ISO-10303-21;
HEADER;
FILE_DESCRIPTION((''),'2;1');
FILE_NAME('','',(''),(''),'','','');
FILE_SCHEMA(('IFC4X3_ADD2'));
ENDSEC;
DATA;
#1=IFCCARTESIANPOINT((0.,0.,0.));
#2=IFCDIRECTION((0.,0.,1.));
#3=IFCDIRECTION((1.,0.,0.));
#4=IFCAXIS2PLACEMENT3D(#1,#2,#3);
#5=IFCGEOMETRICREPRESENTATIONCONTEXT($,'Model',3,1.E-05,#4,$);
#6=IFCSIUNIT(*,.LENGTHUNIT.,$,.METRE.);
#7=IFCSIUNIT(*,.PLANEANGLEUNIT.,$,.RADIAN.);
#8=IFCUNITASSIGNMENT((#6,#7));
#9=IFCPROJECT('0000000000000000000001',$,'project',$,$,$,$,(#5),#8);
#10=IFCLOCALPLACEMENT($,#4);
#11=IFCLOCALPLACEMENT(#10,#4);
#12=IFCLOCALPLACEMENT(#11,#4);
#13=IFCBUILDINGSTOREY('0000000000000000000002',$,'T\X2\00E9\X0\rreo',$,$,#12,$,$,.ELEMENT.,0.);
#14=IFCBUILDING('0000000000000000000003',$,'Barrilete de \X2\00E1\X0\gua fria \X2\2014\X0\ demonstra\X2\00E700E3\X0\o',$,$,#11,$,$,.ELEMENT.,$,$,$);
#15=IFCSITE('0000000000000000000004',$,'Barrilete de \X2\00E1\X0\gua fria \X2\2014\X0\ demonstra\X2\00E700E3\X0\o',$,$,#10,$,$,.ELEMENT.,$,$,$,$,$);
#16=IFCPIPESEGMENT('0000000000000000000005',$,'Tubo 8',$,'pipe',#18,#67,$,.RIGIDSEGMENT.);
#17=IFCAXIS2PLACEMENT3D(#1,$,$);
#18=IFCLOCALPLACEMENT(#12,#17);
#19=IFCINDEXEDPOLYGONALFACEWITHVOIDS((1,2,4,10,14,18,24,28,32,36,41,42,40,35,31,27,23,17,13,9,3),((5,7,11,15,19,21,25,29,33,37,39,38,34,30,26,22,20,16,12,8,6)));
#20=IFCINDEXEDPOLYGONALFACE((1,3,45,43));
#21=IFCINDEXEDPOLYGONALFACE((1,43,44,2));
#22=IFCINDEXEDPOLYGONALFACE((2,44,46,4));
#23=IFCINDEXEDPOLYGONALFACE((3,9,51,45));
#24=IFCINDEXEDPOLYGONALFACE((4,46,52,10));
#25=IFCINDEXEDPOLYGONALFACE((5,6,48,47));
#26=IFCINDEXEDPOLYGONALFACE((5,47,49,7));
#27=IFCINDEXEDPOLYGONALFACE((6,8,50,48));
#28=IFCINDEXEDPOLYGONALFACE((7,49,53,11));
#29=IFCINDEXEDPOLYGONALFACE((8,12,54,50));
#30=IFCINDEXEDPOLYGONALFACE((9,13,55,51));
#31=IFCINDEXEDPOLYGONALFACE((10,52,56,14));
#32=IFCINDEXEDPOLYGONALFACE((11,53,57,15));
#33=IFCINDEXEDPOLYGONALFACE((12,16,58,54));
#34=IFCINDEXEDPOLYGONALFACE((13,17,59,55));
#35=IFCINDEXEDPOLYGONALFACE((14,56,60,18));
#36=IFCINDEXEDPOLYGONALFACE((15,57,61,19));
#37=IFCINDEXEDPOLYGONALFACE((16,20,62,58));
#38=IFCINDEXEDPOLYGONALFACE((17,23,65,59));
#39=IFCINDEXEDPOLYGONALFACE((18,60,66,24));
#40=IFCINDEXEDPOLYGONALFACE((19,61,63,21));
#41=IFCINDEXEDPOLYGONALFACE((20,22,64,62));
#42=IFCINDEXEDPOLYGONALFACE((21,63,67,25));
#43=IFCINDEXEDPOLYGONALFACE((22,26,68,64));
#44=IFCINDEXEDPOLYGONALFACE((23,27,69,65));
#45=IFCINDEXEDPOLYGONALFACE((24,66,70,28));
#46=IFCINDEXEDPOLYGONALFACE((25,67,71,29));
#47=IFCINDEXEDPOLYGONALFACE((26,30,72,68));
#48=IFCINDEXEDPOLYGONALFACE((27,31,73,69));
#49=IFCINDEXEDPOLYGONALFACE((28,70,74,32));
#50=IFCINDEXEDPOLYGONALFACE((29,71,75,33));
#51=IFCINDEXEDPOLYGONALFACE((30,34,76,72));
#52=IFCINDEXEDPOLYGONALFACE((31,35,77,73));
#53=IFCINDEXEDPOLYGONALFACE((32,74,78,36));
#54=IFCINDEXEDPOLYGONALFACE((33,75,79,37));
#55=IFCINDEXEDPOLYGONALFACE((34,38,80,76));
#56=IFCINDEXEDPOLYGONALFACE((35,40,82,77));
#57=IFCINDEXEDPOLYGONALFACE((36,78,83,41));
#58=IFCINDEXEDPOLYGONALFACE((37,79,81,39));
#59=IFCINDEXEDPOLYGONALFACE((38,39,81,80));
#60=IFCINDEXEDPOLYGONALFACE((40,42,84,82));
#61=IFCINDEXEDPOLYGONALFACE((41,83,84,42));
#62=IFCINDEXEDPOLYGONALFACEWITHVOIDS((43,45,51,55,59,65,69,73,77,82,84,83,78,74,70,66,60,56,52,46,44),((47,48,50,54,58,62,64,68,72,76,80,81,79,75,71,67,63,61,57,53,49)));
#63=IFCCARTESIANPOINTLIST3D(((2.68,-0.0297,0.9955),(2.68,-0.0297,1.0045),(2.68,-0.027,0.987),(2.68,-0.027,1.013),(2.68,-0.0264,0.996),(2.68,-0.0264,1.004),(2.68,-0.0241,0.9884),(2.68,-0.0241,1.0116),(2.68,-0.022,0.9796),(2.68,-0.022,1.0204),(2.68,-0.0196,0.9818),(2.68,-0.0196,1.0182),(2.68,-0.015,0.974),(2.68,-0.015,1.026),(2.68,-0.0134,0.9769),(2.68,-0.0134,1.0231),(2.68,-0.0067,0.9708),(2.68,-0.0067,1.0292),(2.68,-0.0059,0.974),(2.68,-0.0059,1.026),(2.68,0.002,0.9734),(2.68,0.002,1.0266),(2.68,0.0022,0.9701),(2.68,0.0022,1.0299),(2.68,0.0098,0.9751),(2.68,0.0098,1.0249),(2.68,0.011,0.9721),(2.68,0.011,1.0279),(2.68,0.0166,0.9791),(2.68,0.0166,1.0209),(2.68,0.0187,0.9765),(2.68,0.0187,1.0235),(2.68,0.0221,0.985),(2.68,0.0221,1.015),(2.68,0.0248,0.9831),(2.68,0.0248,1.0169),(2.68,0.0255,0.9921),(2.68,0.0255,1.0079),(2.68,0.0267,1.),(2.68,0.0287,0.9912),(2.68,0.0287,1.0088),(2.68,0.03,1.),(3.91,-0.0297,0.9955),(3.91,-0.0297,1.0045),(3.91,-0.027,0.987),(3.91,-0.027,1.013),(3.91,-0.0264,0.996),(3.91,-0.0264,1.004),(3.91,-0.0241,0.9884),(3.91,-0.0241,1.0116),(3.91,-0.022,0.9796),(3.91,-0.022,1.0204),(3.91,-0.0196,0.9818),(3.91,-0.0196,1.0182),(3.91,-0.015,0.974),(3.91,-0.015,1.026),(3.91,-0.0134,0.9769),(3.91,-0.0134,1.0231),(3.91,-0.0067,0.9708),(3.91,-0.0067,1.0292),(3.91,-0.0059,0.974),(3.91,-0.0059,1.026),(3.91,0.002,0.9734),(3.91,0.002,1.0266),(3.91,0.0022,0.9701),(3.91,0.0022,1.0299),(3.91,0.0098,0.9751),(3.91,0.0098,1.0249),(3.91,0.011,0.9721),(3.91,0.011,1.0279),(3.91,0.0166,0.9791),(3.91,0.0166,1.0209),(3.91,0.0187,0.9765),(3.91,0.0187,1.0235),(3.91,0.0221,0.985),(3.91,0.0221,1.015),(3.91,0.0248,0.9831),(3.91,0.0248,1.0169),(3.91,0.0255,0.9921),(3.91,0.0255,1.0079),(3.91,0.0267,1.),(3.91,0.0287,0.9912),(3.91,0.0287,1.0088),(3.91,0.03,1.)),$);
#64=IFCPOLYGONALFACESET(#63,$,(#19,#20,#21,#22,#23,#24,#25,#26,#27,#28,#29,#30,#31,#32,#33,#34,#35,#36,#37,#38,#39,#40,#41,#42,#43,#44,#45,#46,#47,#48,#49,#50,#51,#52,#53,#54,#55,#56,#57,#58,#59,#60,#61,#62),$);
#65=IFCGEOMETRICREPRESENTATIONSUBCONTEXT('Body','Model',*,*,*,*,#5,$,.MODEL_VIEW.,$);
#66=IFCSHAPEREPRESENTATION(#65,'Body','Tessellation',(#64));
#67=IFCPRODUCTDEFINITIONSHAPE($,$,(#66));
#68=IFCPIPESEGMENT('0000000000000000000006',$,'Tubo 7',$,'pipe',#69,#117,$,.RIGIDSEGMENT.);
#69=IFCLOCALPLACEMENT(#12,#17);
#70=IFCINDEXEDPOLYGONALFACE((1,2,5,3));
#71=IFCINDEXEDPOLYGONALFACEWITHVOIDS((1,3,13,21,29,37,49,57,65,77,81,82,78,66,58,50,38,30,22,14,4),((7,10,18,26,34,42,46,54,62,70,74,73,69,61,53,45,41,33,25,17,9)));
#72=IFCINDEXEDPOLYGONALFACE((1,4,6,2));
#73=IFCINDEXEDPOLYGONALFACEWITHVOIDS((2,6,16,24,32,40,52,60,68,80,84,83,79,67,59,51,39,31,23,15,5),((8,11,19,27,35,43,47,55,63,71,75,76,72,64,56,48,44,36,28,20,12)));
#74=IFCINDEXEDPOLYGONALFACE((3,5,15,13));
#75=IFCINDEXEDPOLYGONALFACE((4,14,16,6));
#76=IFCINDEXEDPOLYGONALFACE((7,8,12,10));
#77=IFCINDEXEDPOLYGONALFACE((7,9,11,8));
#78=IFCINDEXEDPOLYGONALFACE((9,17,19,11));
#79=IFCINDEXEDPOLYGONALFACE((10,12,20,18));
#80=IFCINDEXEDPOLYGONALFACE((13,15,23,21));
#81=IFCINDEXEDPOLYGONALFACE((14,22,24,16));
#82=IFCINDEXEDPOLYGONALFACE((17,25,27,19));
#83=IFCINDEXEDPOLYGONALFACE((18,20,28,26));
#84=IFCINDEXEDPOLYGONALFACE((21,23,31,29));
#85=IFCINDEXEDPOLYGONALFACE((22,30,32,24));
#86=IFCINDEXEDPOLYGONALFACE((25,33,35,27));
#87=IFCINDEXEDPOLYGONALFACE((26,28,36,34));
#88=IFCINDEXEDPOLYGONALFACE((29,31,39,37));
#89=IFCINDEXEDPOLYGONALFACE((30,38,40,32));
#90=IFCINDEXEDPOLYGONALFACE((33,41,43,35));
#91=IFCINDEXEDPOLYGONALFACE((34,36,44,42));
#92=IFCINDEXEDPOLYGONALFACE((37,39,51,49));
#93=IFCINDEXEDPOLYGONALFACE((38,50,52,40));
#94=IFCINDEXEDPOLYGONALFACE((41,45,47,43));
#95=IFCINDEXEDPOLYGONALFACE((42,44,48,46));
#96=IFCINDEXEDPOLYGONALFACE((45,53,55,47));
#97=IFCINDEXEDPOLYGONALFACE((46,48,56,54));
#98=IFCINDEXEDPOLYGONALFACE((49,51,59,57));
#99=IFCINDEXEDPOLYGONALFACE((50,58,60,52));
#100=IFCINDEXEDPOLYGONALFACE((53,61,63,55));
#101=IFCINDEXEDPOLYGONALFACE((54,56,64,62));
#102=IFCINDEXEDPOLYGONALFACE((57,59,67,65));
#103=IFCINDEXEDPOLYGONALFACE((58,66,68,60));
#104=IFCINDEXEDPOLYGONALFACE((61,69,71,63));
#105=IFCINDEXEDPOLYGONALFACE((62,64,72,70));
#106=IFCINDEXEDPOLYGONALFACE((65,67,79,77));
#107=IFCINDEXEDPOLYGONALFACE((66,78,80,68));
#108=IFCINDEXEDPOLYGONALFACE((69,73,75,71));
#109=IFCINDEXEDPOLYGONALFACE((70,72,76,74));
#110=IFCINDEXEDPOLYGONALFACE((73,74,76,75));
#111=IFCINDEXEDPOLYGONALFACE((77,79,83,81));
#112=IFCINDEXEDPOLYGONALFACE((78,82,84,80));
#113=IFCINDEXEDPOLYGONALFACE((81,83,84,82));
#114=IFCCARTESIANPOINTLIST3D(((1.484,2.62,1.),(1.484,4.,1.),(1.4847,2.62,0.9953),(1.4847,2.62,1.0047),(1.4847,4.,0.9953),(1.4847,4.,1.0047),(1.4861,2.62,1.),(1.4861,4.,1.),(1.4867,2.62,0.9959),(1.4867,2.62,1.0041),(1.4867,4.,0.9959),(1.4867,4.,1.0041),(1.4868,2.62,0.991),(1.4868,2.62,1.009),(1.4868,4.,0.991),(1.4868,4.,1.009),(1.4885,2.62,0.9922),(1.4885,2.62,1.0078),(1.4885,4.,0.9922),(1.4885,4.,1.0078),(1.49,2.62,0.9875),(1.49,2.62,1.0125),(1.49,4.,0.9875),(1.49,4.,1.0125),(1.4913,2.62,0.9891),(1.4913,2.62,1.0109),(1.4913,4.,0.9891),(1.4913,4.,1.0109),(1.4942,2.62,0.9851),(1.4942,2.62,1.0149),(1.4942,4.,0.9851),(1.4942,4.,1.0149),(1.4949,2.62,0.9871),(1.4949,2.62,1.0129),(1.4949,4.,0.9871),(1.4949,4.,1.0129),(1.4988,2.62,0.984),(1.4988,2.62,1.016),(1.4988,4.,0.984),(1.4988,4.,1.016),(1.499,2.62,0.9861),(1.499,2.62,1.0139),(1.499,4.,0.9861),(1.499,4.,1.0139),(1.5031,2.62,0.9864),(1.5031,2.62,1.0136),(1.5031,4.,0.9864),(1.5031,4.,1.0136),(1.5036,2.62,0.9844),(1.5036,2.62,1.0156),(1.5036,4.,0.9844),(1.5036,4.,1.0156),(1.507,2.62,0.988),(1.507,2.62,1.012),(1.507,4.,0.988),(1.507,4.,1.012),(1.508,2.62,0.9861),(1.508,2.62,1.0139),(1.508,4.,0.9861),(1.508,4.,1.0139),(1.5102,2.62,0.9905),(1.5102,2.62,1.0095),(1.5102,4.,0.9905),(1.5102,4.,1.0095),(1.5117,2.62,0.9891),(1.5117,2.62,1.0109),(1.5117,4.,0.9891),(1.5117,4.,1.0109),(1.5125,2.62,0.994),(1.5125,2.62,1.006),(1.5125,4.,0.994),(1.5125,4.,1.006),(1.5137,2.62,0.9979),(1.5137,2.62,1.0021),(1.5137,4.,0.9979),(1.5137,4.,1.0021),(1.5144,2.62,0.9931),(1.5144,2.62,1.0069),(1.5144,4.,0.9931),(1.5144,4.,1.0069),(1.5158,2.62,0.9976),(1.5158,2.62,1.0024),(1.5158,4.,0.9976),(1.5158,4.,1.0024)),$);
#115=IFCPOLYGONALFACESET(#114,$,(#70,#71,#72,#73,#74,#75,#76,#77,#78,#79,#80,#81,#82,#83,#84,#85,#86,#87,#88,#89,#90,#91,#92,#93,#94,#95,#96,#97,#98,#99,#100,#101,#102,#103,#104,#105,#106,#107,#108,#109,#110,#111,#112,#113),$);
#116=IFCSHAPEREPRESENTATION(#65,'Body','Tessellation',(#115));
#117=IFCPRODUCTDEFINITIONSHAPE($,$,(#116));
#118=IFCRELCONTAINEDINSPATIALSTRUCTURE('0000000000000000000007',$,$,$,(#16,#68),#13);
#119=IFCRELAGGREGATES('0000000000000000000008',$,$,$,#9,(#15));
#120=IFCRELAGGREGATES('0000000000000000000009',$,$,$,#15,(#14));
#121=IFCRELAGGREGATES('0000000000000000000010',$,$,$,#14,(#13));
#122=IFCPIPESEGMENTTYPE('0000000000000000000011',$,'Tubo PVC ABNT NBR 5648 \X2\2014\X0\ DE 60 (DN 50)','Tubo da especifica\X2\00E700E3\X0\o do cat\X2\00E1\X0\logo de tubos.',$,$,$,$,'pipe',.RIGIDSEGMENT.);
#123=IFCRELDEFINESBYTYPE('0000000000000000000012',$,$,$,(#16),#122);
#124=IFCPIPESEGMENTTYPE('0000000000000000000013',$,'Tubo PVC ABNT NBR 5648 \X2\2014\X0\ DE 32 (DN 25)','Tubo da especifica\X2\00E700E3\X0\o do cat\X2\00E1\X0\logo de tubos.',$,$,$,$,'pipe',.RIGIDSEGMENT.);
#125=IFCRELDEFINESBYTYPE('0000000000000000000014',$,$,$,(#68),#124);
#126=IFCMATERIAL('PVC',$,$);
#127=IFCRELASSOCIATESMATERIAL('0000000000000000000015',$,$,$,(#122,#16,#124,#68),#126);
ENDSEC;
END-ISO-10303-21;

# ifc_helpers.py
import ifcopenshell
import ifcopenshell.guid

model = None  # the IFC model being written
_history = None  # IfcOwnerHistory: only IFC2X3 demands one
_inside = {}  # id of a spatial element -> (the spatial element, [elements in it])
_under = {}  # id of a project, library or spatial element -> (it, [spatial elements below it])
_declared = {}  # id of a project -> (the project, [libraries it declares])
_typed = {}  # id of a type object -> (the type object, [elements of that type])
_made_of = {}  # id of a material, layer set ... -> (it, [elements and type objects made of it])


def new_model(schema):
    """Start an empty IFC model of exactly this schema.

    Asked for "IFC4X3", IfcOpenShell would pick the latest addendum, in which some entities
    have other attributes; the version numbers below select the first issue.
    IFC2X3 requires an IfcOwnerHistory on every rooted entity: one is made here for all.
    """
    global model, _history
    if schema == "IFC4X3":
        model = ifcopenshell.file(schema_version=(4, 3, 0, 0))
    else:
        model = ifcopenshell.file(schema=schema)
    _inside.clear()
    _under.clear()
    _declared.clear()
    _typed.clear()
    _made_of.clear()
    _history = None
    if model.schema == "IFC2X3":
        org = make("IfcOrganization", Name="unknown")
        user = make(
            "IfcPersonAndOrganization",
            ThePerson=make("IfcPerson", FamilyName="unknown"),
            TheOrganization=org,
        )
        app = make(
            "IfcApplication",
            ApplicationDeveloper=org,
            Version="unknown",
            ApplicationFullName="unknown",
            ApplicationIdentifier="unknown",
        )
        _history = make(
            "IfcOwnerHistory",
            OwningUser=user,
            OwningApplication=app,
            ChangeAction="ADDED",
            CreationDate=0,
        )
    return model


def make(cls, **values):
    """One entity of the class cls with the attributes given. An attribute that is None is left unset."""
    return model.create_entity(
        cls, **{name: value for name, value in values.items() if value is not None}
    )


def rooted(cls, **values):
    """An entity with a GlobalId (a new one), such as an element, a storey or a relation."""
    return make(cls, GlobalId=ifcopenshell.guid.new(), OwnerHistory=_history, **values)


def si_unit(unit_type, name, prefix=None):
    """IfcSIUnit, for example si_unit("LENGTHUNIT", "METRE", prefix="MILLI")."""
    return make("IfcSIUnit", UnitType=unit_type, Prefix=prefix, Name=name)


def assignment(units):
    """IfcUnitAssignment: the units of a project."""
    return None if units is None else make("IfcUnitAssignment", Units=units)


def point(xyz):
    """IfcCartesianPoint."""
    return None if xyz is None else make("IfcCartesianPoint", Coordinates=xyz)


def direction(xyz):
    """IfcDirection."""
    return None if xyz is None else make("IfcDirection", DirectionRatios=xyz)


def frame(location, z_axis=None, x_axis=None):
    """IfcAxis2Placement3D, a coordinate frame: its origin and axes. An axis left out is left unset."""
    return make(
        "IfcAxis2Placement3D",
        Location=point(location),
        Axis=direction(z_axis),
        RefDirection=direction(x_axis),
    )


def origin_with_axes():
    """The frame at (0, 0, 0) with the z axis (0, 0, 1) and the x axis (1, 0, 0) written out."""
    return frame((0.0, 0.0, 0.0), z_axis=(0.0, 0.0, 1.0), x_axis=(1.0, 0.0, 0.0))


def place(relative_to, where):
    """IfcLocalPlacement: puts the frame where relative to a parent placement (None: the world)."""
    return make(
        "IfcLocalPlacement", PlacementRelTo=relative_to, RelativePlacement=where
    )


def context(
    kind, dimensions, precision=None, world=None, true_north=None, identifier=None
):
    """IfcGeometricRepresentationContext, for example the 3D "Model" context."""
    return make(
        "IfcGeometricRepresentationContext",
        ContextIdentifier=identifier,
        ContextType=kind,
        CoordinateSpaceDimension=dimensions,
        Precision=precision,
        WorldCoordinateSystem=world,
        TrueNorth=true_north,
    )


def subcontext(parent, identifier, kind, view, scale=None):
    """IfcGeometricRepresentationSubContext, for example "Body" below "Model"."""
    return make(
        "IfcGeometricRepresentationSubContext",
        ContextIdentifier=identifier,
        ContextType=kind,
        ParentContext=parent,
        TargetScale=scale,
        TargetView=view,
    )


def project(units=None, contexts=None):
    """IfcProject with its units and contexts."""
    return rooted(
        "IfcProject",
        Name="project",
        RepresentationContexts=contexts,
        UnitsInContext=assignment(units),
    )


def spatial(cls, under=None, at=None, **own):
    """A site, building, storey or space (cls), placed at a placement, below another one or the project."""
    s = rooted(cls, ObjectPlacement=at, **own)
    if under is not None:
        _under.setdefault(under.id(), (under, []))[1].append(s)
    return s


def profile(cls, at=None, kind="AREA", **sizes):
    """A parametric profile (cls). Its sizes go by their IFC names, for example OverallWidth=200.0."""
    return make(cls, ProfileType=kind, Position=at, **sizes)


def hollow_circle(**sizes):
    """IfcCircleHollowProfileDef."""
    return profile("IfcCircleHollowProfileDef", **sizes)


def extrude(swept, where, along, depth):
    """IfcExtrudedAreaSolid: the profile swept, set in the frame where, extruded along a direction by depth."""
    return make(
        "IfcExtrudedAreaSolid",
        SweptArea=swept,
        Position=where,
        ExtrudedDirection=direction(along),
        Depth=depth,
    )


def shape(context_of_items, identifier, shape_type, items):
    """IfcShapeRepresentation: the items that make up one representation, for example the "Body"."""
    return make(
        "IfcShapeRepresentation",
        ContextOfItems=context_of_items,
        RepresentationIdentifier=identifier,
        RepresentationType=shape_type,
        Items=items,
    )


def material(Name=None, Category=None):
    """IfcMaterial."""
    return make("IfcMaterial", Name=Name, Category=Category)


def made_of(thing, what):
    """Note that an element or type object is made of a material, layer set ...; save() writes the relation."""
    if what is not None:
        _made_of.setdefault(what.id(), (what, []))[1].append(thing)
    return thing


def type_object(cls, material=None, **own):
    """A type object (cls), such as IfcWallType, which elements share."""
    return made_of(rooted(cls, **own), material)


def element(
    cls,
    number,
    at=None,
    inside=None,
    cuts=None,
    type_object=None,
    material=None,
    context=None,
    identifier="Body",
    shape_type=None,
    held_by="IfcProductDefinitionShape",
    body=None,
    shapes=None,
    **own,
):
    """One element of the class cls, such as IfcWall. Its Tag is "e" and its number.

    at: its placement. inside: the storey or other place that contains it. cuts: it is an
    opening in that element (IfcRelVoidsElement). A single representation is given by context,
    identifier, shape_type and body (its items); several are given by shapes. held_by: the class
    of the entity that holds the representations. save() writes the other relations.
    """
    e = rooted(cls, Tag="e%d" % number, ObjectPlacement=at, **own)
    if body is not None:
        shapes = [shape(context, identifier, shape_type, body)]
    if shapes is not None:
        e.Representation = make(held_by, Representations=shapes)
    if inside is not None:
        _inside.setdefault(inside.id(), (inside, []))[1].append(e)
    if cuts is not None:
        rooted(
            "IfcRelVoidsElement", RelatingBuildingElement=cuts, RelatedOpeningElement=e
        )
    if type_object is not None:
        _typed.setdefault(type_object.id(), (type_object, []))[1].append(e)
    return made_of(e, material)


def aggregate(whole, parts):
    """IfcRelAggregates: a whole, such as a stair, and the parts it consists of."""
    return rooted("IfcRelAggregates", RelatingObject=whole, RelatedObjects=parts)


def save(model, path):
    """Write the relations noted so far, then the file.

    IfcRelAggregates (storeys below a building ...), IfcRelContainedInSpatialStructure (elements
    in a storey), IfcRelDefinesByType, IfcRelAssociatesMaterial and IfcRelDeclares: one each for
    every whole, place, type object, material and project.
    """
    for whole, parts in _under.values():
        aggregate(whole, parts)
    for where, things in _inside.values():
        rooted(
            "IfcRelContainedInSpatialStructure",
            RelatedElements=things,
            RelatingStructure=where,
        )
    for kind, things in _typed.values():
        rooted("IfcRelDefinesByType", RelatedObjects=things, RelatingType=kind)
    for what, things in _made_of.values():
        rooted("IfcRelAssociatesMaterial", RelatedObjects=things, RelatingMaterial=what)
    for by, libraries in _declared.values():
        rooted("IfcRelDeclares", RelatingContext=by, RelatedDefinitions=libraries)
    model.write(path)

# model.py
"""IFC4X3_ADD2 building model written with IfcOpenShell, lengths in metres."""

from ifc_helpers import new_model, si_unit, frame, origin_with_axes, place, context, subcontext, project, spatial, hollow_circle, extrude, material, type_object, element, save


model = new_model("IFC4X3_ADD2")

# Units and contexts
model_context = context("Model", 3, precision=1e-05, world=origin_with_axes())
body_context = subcontext(model_context, "Body", "Model", "MODEL_VIEW")
ifc_project = project(units=[si_unit("LENGTHUNIT", "METRE"), si_unit("PLANEANGLEUNIT", "RADIAN")], contexts=[model_context])

# Site, building, storey
site_placement = place(None, origin_with_axes())
site = spatial("IfcSite", under=ifc_project, at=site_placement, Name="Barrilete de água fria — demonstração", CompositionType="ELEMENT")
building_placement = place(site_placement, origin_with_axes())
building = spatial("IfcBuilding", under=site, at=building_placement, Name="Barrilete de água fria — demonstração", CompositionType="ELEMENT")
storey_placement = place(building_placement, origin_with_axes())
storey = spatial("IfcBuildingStorey", under=building, at=storey_placement, Name="Térreo", CompositionType="ELEMENT", Elevation=0.0)

# Pipe segments
ifc_material = material(Name="PVC")
pipe_segment_type_1 = type_object("IfcPipeSegmentType", Name="Tubo PVC ABNT NBR 5648 — DE 60 (DN 50)", Description="Tubo da especificação do catálogo de tubos.", ElementType="pipe", PredefinedType="RIGIDSEGMENT", material=ifc_material)
pipe_segment_1_placement = place(storey_placement, frame((2.68, 0.0, 1.0), z_axis=(0.0, 0.0, 1.0), x_axis=(1.0, 0.0, 0.0)))
element("IfcPipeSegment", 1, at=pipe_segment_1_placement, inside=storey, type_object=pipe_segment_type_1, material=ifc_material, Name="Tubo 8", ObjectType="pipe", PredefinedType="RIGIDSEGMENT", context=body_context, shape_type="SweptSolid", body=[
    extrude(hollow_circle(Radius=0.03, WallThickness=0.0033), frame((0.0, 0.0, 0.0), z_axis=(1.0, 0.0, 0.0), x_axis=(0.0, 1.0, 0.0)), (0.0, 0.0, 1.0), 1.23),
])
pipe_segment_type_2 = type_object("IfcPipeSegmentType", Name="Tubo PVC ABNT NBR 5648 — DE 32 (DN 25)", Description="Tubo da especificação do catálogo de tubos.", ElementType="pipe", PredefinedType="RIGIDSEGMENT", material=ifc_material)
pipe_segment_2_placement = place(storey_placement, frame((1.5, 2.62, 1.0), z_axis=(0.0, 0.0, 1.0), x_axis=(0.0, 1.0, 0.0)))
element("IfcPipeSegment", 2, at=pipe_segment_2_placement, inside=storey, type_object=pipe_segment_type_2, material=ifc_material, Name="Tubo 7", ObjectType="pipe", PredefinedType="RIGIDSEGMENT", context=body_context, shape_type="SweptSolid", body=[
    extrude(hollow_circle(Radius=0.016, WallThickness=0.0021), frame((0.0, 0.0, 0.0), z_axis=(1.0, 0.0, 0.0), x_axis=(0.0, 1.0, 0.0)), (0.0, 0.0, 1.0), 1.38),
])

save(model, "model.ifc")
